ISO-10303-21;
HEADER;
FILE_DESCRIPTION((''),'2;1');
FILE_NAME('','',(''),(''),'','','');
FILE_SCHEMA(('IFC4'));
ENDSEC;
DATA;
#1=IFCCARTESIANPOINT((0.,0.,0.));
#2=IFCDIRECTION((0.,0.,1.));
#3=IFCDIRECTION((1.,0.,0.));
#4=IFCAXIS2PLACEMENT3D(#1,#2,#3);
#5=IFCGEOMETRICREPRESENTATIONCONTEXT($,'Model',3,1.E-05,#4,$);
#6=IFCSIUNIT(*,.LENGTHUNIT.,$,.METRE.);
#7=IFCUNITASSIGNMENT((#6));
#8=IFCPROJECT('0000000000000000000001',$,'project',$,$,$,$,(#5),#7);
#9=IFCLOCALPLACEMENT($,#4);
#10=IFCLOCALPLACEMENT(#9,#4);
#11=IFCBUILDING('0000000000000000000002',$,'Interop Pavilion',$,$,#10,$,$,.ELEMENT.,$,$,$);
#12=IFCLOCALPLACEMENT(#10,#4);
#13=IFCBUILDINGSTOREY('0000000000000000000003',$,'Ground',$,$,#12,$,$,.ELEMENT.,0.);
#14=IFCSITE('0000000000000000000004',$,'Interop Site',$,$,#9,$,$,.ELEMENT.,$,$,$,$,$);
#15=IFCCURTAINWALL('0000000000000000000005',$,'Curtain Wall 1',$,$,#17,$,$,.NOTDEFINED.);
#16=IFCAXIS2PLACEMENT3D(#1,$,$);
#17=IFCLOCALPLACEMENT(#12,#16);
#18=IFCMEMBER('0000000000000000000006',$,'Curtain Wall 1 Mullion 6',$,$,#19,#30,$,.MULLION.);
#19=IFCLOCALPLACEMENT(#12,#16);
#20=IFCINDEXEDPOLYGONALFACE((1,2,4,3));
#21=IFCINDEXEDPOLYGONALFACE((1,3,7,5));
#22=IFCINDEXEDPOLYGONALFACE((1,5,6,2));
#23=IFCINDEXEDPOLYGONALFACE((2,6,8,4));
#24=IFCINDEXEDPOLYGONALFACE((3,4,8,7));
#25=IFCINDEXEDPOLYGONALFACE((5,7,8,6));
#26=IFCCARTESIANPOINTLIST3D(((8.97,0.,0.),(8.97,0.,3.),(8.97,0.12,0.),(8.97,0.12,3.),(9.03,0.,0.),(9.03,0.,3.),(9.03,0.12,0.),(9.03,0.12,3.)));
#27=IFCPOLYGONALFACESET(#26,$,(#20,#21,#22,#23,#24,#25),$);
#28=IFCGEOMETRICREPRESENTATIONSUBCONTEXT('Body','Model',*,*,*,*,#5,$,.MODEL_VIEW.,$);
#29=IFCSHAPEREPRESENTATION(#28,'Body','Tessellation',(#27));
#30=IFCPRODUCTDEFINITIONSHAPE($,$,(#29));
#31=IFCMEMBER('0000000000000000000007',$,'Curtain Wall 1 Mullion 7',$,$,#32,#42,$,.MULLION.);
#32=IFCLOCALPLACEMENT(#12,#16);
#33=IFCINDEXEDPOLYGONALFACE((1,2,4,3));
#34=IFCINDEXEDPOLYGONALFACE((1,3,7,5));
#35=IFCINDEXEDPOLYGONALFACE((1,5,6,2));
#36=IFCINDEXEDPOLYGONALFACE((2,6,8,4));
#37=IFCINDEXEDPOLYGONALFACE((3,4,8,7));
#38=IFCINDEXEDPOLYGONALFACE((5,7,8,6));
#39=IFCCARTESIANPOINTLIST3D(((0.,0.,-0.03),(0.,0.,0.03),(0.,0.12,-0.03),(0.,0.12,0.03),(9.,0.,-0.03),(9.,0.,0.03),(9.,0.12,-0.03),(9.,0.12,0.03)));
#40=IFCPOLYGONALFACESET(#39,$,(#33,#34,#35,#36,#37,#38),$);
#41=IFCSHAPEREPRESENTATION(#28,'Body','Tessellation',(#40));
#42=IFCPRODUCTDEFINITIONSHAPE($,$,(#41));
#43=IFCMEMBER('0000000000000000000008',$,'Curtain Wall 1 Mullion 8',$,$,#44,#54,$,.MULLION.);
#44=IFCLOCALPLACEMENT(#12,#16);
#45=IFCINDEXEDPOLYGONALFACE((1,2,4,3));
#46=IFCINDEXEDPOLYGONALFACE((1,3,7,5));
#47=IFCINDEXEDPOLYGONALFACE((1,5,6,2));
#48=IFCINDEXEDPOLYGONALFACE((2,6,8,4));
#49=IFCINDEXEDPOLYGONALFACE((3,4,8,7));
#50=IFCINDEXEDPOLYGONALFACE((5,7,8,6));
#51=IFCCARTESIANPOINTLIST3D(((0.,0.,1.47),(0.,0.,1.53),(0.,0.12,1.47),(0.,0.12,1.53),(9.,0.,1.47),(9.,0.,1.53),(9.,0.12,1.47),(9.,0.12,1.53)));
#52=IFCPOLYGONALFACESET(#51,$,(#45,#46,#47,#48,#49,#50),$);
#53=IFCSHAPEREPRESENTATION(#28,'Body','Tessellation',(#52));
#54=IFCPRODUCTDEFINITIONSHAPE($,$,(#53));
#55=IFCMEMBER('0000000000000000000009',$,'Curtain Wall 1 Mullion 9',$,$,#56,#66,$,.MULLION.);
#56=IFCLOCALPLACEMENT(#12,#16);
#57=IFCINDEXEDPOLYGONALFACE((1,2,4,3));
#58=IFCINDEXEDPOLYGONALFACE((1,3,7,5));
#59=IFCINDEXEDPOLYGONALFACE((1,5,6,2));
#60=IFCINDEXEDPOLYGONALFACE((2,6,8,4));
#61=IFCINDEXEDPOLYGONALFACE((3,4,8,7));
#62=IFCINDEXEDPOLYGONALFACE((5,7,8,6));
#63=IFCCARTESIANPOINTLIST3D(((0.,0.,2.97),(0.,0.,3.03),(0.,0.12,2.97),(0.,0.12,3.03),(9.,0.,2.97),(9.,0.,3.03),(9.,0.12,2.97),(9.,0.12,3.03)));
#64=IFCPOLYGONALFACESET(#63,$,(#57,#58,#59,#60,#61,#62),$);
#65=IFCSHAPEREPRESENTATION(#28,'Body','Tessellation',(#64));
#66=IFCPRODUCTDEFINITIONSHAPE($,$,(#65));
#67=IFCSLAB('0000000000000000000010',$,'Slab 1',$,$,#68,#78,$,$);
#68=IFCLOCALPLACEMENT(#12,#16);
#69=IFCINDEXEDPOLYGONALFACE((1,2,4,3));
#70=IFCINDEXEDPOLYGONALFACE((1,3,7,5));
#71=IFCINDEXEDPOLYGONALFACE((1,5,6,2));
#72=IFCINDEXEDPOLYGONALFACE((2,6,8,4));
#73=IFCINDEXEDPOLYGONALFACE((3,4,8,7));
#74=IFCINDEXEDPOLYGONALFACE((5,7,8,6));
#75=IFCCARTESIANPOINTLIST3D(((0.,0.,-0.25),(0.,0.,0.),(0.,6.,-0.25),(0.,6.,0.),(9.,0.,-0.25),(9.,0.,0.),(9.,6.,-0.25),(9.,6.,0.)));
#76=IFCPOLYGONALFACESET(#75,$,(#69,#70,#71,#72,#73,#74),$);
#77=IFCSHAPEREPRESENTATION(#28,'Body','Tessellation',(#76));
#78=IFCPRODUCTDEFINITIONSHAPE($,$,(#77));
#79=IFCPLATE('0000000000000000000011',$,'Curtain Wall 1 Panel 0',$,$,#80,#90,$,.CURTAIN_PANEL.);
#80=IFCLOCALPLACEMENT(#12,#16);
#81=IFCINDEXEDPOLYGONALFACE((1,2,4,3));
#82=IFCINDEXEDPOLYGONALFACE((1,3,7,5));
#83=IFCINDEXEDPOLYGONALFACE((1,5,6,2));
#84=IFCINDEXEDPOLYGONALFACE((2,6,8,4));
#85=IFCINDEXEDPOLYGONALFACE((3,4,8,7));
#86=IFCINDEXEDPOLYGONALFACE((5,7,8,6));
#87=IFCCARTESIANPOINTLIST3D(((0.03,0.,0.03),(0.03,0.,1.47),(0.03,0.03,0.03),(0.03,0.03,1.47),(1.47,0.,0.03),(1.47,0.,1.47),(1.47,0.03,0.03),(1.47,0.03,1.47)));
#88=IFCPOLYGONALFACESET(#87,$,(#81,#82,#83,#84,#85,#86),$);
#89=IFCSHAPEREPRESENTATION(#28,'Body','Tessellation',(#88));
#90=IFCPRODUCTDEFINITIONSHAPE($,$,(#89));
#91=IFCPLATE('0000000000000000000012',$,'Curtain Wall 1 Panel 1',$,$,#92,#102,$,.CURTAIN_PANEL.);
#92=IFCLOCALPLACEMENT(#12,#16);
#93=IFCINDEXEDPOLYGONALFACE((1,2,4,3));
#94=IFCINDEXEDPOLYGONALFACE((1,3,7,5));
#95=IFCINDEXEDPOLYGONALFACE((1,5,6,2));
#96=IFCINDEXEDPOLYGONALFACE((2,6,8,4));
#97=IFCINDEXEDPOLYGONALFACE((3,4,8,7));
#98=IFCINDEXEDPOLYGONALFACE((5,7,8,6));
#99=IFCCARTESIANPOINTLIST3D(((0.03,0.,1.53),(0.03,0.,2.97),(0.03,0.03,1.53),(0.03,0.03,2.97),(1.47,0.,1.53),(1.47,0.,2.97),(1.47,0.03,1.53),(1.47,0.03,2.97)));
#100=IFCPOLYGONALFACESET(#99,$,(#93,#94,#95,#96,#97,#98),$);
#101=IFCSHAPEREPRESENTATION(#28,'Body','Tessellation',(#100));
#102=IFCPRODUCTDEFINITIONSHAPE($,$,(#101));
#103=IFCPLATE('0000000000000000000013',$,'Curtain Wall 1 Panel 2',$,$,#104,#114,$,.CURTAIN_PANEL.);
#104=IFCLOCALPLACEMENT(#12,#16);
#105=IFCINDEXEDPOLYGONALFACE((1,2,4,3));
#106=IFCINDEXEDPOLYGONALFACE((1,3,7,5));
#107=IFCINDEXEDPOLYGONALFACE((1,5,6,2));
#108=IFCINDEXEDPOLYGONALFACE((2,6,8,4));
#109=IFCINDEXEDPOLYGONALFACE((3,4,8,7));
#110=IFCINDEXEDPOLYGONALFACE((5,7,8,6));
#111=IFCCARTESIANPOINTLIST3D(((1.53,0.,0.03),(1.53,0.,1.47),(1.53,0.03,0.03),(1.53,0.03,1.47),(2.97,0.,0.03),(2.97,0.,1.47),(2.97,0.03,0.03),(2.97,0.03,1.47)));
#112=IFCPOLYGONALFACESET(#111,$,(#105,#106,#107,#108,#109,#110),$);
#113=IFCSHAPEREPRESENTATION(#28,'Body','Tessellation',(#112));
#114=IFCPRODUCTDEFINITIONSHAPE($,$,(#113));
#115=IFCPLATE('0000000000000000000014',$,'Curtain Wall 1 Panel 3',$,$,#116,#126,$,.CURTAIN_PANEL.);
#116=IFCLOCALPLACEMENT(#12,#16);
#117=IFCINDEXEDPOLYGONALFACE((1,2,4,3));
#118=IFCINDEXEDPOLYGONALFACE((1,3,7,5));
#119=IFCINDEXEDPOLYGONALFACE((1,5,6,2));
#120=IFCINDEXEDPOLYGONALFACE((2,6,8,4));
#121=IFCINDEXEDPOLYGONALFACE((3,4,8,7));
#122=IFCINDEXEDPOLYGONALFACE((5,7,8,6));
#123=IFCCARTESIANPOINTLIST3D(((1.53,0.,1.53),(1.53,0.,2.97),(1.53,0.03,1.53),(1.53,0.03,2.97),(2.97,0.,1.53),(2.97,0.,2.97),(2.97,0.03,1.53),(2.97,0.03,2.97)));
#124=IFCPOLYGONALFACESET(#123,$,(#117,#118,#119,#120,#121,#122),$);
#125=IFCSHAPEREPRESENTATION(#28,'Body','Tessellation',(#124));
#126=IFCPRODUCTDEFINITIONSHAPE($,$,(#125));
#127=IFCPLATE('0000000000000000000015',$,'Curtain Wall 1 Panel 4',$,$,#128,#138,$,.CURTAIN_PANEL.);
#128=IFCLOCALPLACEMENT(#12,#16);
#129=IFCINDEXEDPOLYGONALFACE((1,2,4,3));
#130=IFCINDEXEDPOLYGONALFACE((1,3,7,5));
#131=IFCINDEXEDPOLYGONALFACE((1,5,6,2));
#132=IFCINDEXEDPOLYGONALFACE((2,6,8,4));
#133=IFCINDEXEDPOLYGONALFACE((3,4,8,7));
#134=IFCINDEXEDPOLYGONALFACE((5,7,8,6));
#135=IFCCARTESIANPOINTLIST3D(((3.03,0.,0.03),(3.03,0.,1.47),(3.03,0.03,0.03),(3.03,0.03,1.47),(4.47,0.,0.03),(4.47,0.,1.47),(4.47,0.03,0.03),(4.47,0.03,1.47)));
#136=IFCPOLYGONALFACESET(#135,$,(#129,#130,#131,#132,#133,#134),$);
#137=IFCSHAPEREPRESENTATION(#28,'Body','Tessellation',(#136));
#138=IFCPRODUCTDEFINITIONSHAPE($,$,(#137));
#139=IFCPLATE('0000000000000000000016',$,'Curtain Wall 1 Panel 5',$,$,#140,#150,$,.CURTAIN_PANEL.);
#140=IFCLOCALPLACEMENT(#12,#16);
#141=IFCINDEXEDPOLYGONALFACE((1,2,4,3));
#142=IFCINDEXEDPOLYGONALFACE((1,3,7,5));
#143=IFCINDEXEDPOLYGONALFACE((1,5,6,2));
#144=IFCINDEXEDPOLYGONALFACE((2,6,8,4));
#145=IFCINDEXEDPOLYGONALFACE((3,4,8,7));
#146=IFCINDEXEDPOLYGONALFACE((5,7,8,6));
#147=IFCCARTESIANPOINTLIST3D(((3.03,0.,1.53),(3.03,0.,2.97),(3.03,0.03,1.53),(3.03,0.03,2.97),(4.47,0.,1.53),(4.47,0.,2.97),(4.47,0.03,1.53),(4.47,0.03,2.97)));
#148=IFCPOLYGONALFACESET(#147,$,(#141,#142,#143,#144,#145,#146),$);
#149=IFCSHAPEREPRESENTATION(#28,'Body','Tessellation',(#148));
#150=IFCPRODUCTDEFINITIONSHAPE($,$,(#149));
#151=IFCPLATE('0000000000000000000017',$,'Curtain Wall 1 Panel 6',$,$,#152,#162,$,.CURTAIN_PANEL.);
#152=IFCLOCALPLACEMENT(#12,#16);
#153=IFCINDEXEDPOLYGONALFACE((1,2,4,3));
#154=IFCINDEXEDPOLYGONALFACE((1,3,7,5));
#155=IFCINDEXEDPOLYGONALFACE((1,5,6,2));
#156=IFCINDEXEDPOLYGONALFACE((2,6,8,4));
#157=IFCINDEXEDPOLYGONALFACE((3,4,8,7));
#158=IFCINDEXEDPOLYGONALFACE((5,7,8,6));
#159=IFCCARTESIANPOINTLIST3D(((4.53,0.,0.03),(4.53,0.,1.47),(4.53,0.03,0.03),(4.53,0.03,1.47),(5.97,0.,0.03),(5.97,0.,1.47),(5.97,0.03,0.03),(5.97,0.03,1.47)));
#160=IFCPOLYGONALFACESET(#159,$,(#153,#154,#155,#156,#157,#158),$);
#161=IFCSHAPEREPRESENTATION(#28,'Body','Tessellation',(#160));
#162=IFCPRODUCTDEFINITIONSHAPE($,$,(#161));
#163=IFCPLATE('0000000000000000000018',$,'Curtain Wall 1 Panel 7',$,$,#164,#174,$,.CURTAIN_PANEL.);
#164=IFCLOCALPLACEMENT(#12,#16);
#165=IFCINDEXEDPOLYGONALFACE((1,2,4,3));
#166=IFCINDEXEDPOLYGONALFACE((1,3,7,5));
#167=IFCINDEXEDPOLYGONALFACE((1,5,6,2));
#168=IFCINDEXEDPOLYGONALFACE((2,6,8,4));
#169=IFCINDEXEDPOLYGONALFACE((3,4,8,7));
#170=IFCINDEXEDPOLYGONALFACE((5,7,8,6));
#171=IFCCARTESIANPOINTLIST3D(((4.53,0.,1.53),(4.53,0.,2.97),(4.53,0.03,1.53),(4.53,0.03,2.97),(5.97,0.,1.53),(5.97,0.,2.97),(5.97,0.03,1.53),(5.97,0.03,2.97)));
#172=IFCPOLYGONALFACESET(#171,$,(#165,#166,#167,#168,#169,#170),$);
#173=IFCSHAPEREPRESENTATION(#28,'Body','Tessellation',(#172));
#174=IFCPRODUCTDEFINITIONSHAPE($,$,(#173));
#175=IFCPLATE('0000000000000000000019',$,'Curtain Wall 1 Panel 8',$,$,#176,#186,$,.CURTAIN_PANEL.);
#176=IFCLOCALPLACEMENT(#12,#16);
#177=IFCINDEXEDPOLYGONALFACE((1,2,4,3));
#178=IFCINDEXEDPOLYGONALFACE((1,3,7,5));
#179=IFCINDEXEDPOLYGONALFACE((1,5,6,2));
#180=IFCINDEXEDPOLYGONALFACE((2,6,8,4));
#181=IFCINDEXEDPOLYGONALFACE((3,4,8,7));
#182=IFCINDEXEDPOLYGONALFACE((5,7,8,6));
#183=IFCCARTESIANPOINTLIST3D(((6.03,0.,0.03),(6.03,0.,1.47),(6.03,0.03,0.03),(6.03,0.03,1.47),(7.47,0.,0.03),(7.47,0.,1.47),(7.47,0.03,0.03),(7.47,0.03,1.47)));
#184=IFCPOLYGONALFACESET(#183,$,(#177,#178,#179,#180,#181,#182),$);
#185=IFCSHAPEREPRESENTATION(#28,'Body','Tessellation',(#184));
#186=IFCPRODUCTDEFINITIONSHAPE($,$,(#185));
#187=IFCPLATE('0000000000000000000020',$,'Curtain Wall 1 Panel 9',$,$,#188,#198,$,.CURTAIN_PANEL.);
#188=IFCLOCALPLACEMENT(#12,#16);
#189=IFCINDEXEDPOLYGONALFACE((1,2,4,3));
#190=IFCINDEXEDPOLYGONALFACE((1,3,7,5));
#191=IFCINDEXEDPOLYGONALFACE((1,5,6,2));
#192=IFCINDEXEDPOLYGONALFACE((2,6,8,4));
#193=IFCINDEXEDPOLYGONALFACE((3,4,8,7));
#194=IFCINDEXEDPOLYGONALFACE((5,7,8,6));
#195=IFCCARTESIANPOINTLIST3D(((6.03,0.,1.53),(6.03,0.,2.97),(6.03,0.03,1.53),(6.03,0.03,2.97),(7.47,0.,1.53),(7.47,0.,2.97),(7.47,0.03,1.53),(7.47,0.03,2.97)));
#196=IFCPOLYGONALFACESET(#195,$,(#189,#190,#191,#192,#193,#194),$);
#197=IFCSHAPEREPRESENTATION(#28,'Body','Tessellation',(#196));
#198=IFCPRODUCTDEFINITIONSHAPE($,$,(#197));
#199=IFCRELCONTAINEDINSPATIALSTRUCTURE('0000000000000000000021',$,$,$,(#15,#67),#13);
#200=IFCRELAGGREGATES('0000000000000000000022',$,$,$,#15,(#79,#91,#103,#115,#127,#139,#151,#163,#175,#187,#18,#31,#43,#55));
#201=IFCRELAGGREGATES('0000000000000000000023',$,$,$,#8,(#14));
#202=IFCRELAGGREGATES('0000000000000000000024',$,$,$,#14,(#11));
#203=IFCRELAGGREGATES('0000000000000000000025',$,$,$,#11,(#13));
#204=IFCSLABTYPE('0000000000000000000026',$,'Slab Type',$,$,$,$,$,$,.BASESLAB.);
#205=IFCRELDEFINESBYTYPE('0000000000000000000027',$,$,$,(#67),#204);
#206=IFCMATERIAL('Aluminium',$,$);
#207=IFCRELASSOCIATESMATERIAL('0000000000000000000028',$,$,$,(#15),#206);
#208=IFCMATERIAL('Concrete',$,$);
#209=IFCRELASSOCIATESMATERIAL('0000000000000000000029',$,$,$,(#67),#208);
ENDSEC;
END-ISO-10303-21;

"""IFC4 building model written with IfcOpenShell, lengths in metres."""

from ifc_helpers import new_model, si_unit, frame, frame_2d, origin_with_axes, place, context, subcontext, project, spatial, rectangle, extrude, material, type_object, element, aggregate, save


model = new_model("IFC4")

# Units and contexts
model_context = context("Model", 3, precision=1e-05, world=origin_with_axes())
body_context = subcontext(model_context, "Body", "Model", "MODEL_VIEW")
ifc_project = project(units=[si_unit("LENGTHUNIT", "METRE")], contexts=[model_context])

# Site, building, storey
site_placement = place(None, origin_with_axes())
site = spatial("IfcSite", under=ifc_project, at=site_placement, Name="Interop Site", CompositionType="ELEMENT")
building_placement = place(site_placement, origin_with_axes())
building = spatial("IfcBuilding", under=site, at=building_placement, Name="Interop Pavilion", CompositionType="ELEMENT")
storey_placement = place(building_placement, origin_with_axes())
storey = spatial("IfcBuildingStorey", under=building, at=storey_placement, Name="Ground", CompositionType="ELEMENT", Elevation=0.0)

# Shared definitions
ifc_material_1 = material(Name="Concrete")

# Curtain wall, members
ifc_material_2 = material(Name="Aluminium")
curtain_wall_placement = place(storey_placement, origin_with_axes())
curtain_wall = element("IfcCurtainWall", 1, at=curtain_wall_placement, inside=storey, material=ifc_material_2, Name="Curtain Wall 1", PredefinedType="NOTDEFINED")
member_1_placement = place(curtain_wall_placement, frame((8.97, 0.0, 0.0), z_axis=(0.0, 0.0, 1.0), x_axis=(1.0, 0.0, 0.0)))
member_1 = element("IfcMember", 2, at=member_1_placement, Name="Curtain Wall 1 Mullion 6", PredefinedType="MULLION", context=body_context, shape_type="SweptSolid", body=[
    extrude(rectangle(XDim=0.06, YDim=0.12, at=frame_2d((0.03, 0.06))), origin_with_axes(), (0.0, 0.0, 1.0), 3.0),
])
member_2_placement = place(curtain_wall_placement, frame((0.0, 0.0, -0.03), z_axis=(0.0, 0.0, 1.0), x_axis=(1.0, 0.0, 0.0)))
member_2 = element("IfcMember", 3, at=member_2_placement, Name="Curtain Wall 1 Mullion 7", PredefinedType="MULLION", context=body_context, shape_type="SweptSolid", body=[
    extrude(rectangle(XDim=9.0, YDim=0.12, at=frame_2d((4.5, 0.06))), origin_with_axes(), (0.0, 0.0, 1.0), 0.06),
])
member_3_placement = place(curtain_wall_placement, frame((0.0, 0.0, 1.47), z_axis=(0.0, 0.0, 1.0), x_axis=(1.0, 0.0, 0.0)))
member_3 = element("IfcMember", 4, at=member_3_placement, Name="Curtain Wall 1 Mullion 8", PredefinedType="MULLION", context=body_context, shape_type="SweptSolid", body=[
    extrude(rectangle(XDim=9.0, YDim=0.12, at=frame_2d((4.5, 0.06))), origin_with_axes(), (0.0, 0.0, 1.0), 0.06),
])
member_4_placement = place(curtain_wall_placement, frame((0.0, 0.0, 2.97), z_axis=(0.0, 0.0, 1.0), x_axis=(1.0, 0.0, 0.0)))
member_4 = element("IfcMember", 5, at=member_4_placement, Name="Curtain Wall 1 Mullion 9", PredefinedType="MULLION", context=body_context, shape_type="SweptSolid", body=[
    extrude(rectangle(XDim=9.0, YDim=0.12, at=frame_2d((4.5, 0.06))), origin_with_axes(), (0.0, 0.0, 1.0), 0.06),
])

# Slab
slab_type = type_object("IfcSlabType", Name="Slab Type", PredefinedType="BASESLAB")
slab_placement = place(storey_placement, frame((0.0, 0.0, -0.25), z_axis=(0.0, 0.0, 1.0), x_axis=(1.0, 0.0, 0.0)))
element("IfcSlab", 6, at=slab_placement, inside=storey, type_object=slab_type, material=ifc_material_1, Name="Slab 1", context=body_context, shape_type="SweptSolid", body=[
    extrude(rectangle(XDim=9.0, YDim=6.0, at=frame_2d((4.5, 3.0))), origin_with_axes(), (0.0, 0.0, 1.0), 0.25),
])

# Plates
plate_1_placement = place(curtain_wall_placement, frame((0.03, 0.0, 0.03), z_axis=(0.0, 0.0, 1.0), x_axis=(1.0, 0.0, 0.0)))
plate_1 = element("IfcPlate", 7, at=plate_1_placement, Name="Curtain Wall 1 Panel 0", PredefinedType="CURTAIN_PANEL", context=body_context, shape_type="SweptSolid", body=[
    extrude(rectangle(XDim=1.44, YDim=0.03, at=frame_2d((0.72, 0.015))), origin_with_axes(), (0.0, 0.0, 1.0), 1.44),
])
plate_2_placement = place(curtain_wall_placement, frame((0.03, 0.0, 1.53), z_axis=(0.0, 0.0, 1.0), x_axis=(1.0, 0.0, 0.0)))
plate_2 = element("IfcPlate", 8, at=plate_2_placement, Name="Curtain Wall 1 Panel 1", PredefinedType="CURTAIN_PANEL", context=body_context, shape_type="SweptSolid", body=[
    extrude(rectangle(XDim=1.44, YDim=0.03, at=frame_2d((0.72, 0.015))), origin_with_axes(), (0.0, 0.0, 1.0), 1.44),
])
plate_3_placement = place(curtain_wall_placement, frame((1.53, 0.0, 0.03), z_axis=(0.0, 0.0, 1.0), x_axis=(1.0, 0.0, 0.0)))
plate_3 = element("IfcPlate", 9, at=plate_3_placement, Name="Curtain Wall 1 Panel 2", PredefinedType="CURTAIN_PANEL", context=body_context, shape_type="SweptSolid", body=[
    extrude(rectangle(XDim=1.44, YDim=0.03, at=frame_2d((0.72, 0.015))), origin_with_axes(), (0.0, 0.0, 1.0), 1.44),
])
plate_4_placement = place(curtain_wall_placement, frame((1.53, 0.0, 1.53), z_axis=(0.0, 0.0, 1.0), x_axis=(1.0, 0.0, 0.0)))
plate_4 = element("IfcPlate", 10, at=plate_4_placement, Name="Curtain Wall 1 Panel 3", PredefinedType="CURTAIN_PANEL", context=body_context, shape_type="SweptSolid", body=[
    extrude(rectangle(XDim=1.44, YDim=0.03, at=frame_2d((0.72, 0.015))), origin_with_axes(), (0.0, 0.0, 1.0), 1.44),
])
plate_5_placement = place(curtain_wall_placement, frame((3.03, 0.0, 0.03), z_axis=(0.0, 0.0, 1.0), x_axis=(1.0, 0.0, 0.0)))
plate_5 = element("IfcPlate", 11, at=plate_5_placement, Name="Curtain Wall 1 Panel 4", PredefinedType="CURTAIN_PANEL", context=body_context, shape_type="SweptSolid", body=[
    extrude(rectangle(XDim=1.44, YDim=0.03, at=frame_2d((0.72, 0.015))), origin_with_axes(), (0.0, 0.0, 1.0), 1.44),
])
plate_6_placement = place(curtain_wall_placement, frame((3.03, 0.0, 1.53), z_axis=(0.0, 0.0, 1.0), x_axis=(1.0, 0.0, 0.0)))
plate_6 = element("IfcPlate", 12, at=plate_6_placement, Name="Curtain Wall 1 Panel 5", PredefinedType="CURTAIN_PANEL", context=body_context, shape_type="SweptSolid", body=[
    extrude(rectangle(XDim=1.44, YDim=0.03, at=frame_2d((0.72, 0.015))), origin_with_axes(), (0.0, 0.0, 1.0), 1.44),
])
plate_7_placement = place(curtain_wall_placement, frame((4.53, 0.0, 0.03), z_axis=(0.0, 0.0, 1.0), x_axis=(1.0, 0.0, 0.0)))
plate_7 = element("IfcPlate", 13, at=plate_7_placement, Name="Curtain Wall 1 Panel 6", PredefinedType="CURTAIN_PANEL", context=body_context, shape_type="SweptSolid", body=[
    extrude(rectangle(XDim=1.44, YDim=0.03, at=frame_2d((0.72, 0.015))), origin_with_axes(), (0.0, 0.0, 1.0), 1.44),
])
plate_8_placement = place(curtain_wall_placement, frame((4.53, 0.0, 1.53), z_axis=(0.0, 0.0, 1.0), x_axis=(1.0, 0.0, 0.0)))
plate_8 = element("IfcPlate", 14, at=plate_8_placement, Name="Curtain Wall 1 Panel 7", PredefinedType="CURTAIN_PANEL", context=body_context, shape_type="SweptSolid", body=[
    extrude(rectangle(XDim=1.44, YDim=0.03, at=frame_2d((0.72, 0.015))), origin_with_axes(), (0.0, 0.0, 1.0), 1.44),
])
plate_9_placement = place(curtain_wall_placement, frame((6.03, 0.0, 0.03), z_axis=(0.0, 0.0, 1.0), x_axis=(1.0, 0.0, 0.0)))
plate_9 = element("IfcPlate", 15, at=plate_9_placement, Name="Curtain Wall 1 Panel 8", PredefinedType="CURTAIN_PANEL", context=body_context, shape_type="SweptSolid", body=[
    extrude(rectangle(XDim=1.44, YDim=0.03, at=frame_2d((0.72, 0.015))), origin_with_axes(), (0.0, 0.0, 1.0), 1.44),
])
plate_10_placement = place(curtain_wall_placement, frame((6.03, 0.0, 1.53), z_axis=(0.0, 0.0, 1.0), x_axis=(1.0, 0.0, 0.0)))
plate_10 = element("IfcPlate", 16, at=plate_10_placement, Name="Curtain Wall 1 Panel 9", PredefinedType="CURTAIN_PANEL", context=body_context, shape_type="SweptSolid", body=[
    extrude(rectangle(XDim=1.44, YDim=0.03, at=frame_2d((0.72, 0.015))), origin_with_axes(), (0.0, 0.0, 1.0), 1.44),
])
aggregate(curtain_wall, [plate_1, plate_2, plate_3, plate_4, plate_5, plate_6, plate_7, plate_8, plate_9, plate_10, member_1, member_2, member_3, member_4])

save(model, "model.ifc")
